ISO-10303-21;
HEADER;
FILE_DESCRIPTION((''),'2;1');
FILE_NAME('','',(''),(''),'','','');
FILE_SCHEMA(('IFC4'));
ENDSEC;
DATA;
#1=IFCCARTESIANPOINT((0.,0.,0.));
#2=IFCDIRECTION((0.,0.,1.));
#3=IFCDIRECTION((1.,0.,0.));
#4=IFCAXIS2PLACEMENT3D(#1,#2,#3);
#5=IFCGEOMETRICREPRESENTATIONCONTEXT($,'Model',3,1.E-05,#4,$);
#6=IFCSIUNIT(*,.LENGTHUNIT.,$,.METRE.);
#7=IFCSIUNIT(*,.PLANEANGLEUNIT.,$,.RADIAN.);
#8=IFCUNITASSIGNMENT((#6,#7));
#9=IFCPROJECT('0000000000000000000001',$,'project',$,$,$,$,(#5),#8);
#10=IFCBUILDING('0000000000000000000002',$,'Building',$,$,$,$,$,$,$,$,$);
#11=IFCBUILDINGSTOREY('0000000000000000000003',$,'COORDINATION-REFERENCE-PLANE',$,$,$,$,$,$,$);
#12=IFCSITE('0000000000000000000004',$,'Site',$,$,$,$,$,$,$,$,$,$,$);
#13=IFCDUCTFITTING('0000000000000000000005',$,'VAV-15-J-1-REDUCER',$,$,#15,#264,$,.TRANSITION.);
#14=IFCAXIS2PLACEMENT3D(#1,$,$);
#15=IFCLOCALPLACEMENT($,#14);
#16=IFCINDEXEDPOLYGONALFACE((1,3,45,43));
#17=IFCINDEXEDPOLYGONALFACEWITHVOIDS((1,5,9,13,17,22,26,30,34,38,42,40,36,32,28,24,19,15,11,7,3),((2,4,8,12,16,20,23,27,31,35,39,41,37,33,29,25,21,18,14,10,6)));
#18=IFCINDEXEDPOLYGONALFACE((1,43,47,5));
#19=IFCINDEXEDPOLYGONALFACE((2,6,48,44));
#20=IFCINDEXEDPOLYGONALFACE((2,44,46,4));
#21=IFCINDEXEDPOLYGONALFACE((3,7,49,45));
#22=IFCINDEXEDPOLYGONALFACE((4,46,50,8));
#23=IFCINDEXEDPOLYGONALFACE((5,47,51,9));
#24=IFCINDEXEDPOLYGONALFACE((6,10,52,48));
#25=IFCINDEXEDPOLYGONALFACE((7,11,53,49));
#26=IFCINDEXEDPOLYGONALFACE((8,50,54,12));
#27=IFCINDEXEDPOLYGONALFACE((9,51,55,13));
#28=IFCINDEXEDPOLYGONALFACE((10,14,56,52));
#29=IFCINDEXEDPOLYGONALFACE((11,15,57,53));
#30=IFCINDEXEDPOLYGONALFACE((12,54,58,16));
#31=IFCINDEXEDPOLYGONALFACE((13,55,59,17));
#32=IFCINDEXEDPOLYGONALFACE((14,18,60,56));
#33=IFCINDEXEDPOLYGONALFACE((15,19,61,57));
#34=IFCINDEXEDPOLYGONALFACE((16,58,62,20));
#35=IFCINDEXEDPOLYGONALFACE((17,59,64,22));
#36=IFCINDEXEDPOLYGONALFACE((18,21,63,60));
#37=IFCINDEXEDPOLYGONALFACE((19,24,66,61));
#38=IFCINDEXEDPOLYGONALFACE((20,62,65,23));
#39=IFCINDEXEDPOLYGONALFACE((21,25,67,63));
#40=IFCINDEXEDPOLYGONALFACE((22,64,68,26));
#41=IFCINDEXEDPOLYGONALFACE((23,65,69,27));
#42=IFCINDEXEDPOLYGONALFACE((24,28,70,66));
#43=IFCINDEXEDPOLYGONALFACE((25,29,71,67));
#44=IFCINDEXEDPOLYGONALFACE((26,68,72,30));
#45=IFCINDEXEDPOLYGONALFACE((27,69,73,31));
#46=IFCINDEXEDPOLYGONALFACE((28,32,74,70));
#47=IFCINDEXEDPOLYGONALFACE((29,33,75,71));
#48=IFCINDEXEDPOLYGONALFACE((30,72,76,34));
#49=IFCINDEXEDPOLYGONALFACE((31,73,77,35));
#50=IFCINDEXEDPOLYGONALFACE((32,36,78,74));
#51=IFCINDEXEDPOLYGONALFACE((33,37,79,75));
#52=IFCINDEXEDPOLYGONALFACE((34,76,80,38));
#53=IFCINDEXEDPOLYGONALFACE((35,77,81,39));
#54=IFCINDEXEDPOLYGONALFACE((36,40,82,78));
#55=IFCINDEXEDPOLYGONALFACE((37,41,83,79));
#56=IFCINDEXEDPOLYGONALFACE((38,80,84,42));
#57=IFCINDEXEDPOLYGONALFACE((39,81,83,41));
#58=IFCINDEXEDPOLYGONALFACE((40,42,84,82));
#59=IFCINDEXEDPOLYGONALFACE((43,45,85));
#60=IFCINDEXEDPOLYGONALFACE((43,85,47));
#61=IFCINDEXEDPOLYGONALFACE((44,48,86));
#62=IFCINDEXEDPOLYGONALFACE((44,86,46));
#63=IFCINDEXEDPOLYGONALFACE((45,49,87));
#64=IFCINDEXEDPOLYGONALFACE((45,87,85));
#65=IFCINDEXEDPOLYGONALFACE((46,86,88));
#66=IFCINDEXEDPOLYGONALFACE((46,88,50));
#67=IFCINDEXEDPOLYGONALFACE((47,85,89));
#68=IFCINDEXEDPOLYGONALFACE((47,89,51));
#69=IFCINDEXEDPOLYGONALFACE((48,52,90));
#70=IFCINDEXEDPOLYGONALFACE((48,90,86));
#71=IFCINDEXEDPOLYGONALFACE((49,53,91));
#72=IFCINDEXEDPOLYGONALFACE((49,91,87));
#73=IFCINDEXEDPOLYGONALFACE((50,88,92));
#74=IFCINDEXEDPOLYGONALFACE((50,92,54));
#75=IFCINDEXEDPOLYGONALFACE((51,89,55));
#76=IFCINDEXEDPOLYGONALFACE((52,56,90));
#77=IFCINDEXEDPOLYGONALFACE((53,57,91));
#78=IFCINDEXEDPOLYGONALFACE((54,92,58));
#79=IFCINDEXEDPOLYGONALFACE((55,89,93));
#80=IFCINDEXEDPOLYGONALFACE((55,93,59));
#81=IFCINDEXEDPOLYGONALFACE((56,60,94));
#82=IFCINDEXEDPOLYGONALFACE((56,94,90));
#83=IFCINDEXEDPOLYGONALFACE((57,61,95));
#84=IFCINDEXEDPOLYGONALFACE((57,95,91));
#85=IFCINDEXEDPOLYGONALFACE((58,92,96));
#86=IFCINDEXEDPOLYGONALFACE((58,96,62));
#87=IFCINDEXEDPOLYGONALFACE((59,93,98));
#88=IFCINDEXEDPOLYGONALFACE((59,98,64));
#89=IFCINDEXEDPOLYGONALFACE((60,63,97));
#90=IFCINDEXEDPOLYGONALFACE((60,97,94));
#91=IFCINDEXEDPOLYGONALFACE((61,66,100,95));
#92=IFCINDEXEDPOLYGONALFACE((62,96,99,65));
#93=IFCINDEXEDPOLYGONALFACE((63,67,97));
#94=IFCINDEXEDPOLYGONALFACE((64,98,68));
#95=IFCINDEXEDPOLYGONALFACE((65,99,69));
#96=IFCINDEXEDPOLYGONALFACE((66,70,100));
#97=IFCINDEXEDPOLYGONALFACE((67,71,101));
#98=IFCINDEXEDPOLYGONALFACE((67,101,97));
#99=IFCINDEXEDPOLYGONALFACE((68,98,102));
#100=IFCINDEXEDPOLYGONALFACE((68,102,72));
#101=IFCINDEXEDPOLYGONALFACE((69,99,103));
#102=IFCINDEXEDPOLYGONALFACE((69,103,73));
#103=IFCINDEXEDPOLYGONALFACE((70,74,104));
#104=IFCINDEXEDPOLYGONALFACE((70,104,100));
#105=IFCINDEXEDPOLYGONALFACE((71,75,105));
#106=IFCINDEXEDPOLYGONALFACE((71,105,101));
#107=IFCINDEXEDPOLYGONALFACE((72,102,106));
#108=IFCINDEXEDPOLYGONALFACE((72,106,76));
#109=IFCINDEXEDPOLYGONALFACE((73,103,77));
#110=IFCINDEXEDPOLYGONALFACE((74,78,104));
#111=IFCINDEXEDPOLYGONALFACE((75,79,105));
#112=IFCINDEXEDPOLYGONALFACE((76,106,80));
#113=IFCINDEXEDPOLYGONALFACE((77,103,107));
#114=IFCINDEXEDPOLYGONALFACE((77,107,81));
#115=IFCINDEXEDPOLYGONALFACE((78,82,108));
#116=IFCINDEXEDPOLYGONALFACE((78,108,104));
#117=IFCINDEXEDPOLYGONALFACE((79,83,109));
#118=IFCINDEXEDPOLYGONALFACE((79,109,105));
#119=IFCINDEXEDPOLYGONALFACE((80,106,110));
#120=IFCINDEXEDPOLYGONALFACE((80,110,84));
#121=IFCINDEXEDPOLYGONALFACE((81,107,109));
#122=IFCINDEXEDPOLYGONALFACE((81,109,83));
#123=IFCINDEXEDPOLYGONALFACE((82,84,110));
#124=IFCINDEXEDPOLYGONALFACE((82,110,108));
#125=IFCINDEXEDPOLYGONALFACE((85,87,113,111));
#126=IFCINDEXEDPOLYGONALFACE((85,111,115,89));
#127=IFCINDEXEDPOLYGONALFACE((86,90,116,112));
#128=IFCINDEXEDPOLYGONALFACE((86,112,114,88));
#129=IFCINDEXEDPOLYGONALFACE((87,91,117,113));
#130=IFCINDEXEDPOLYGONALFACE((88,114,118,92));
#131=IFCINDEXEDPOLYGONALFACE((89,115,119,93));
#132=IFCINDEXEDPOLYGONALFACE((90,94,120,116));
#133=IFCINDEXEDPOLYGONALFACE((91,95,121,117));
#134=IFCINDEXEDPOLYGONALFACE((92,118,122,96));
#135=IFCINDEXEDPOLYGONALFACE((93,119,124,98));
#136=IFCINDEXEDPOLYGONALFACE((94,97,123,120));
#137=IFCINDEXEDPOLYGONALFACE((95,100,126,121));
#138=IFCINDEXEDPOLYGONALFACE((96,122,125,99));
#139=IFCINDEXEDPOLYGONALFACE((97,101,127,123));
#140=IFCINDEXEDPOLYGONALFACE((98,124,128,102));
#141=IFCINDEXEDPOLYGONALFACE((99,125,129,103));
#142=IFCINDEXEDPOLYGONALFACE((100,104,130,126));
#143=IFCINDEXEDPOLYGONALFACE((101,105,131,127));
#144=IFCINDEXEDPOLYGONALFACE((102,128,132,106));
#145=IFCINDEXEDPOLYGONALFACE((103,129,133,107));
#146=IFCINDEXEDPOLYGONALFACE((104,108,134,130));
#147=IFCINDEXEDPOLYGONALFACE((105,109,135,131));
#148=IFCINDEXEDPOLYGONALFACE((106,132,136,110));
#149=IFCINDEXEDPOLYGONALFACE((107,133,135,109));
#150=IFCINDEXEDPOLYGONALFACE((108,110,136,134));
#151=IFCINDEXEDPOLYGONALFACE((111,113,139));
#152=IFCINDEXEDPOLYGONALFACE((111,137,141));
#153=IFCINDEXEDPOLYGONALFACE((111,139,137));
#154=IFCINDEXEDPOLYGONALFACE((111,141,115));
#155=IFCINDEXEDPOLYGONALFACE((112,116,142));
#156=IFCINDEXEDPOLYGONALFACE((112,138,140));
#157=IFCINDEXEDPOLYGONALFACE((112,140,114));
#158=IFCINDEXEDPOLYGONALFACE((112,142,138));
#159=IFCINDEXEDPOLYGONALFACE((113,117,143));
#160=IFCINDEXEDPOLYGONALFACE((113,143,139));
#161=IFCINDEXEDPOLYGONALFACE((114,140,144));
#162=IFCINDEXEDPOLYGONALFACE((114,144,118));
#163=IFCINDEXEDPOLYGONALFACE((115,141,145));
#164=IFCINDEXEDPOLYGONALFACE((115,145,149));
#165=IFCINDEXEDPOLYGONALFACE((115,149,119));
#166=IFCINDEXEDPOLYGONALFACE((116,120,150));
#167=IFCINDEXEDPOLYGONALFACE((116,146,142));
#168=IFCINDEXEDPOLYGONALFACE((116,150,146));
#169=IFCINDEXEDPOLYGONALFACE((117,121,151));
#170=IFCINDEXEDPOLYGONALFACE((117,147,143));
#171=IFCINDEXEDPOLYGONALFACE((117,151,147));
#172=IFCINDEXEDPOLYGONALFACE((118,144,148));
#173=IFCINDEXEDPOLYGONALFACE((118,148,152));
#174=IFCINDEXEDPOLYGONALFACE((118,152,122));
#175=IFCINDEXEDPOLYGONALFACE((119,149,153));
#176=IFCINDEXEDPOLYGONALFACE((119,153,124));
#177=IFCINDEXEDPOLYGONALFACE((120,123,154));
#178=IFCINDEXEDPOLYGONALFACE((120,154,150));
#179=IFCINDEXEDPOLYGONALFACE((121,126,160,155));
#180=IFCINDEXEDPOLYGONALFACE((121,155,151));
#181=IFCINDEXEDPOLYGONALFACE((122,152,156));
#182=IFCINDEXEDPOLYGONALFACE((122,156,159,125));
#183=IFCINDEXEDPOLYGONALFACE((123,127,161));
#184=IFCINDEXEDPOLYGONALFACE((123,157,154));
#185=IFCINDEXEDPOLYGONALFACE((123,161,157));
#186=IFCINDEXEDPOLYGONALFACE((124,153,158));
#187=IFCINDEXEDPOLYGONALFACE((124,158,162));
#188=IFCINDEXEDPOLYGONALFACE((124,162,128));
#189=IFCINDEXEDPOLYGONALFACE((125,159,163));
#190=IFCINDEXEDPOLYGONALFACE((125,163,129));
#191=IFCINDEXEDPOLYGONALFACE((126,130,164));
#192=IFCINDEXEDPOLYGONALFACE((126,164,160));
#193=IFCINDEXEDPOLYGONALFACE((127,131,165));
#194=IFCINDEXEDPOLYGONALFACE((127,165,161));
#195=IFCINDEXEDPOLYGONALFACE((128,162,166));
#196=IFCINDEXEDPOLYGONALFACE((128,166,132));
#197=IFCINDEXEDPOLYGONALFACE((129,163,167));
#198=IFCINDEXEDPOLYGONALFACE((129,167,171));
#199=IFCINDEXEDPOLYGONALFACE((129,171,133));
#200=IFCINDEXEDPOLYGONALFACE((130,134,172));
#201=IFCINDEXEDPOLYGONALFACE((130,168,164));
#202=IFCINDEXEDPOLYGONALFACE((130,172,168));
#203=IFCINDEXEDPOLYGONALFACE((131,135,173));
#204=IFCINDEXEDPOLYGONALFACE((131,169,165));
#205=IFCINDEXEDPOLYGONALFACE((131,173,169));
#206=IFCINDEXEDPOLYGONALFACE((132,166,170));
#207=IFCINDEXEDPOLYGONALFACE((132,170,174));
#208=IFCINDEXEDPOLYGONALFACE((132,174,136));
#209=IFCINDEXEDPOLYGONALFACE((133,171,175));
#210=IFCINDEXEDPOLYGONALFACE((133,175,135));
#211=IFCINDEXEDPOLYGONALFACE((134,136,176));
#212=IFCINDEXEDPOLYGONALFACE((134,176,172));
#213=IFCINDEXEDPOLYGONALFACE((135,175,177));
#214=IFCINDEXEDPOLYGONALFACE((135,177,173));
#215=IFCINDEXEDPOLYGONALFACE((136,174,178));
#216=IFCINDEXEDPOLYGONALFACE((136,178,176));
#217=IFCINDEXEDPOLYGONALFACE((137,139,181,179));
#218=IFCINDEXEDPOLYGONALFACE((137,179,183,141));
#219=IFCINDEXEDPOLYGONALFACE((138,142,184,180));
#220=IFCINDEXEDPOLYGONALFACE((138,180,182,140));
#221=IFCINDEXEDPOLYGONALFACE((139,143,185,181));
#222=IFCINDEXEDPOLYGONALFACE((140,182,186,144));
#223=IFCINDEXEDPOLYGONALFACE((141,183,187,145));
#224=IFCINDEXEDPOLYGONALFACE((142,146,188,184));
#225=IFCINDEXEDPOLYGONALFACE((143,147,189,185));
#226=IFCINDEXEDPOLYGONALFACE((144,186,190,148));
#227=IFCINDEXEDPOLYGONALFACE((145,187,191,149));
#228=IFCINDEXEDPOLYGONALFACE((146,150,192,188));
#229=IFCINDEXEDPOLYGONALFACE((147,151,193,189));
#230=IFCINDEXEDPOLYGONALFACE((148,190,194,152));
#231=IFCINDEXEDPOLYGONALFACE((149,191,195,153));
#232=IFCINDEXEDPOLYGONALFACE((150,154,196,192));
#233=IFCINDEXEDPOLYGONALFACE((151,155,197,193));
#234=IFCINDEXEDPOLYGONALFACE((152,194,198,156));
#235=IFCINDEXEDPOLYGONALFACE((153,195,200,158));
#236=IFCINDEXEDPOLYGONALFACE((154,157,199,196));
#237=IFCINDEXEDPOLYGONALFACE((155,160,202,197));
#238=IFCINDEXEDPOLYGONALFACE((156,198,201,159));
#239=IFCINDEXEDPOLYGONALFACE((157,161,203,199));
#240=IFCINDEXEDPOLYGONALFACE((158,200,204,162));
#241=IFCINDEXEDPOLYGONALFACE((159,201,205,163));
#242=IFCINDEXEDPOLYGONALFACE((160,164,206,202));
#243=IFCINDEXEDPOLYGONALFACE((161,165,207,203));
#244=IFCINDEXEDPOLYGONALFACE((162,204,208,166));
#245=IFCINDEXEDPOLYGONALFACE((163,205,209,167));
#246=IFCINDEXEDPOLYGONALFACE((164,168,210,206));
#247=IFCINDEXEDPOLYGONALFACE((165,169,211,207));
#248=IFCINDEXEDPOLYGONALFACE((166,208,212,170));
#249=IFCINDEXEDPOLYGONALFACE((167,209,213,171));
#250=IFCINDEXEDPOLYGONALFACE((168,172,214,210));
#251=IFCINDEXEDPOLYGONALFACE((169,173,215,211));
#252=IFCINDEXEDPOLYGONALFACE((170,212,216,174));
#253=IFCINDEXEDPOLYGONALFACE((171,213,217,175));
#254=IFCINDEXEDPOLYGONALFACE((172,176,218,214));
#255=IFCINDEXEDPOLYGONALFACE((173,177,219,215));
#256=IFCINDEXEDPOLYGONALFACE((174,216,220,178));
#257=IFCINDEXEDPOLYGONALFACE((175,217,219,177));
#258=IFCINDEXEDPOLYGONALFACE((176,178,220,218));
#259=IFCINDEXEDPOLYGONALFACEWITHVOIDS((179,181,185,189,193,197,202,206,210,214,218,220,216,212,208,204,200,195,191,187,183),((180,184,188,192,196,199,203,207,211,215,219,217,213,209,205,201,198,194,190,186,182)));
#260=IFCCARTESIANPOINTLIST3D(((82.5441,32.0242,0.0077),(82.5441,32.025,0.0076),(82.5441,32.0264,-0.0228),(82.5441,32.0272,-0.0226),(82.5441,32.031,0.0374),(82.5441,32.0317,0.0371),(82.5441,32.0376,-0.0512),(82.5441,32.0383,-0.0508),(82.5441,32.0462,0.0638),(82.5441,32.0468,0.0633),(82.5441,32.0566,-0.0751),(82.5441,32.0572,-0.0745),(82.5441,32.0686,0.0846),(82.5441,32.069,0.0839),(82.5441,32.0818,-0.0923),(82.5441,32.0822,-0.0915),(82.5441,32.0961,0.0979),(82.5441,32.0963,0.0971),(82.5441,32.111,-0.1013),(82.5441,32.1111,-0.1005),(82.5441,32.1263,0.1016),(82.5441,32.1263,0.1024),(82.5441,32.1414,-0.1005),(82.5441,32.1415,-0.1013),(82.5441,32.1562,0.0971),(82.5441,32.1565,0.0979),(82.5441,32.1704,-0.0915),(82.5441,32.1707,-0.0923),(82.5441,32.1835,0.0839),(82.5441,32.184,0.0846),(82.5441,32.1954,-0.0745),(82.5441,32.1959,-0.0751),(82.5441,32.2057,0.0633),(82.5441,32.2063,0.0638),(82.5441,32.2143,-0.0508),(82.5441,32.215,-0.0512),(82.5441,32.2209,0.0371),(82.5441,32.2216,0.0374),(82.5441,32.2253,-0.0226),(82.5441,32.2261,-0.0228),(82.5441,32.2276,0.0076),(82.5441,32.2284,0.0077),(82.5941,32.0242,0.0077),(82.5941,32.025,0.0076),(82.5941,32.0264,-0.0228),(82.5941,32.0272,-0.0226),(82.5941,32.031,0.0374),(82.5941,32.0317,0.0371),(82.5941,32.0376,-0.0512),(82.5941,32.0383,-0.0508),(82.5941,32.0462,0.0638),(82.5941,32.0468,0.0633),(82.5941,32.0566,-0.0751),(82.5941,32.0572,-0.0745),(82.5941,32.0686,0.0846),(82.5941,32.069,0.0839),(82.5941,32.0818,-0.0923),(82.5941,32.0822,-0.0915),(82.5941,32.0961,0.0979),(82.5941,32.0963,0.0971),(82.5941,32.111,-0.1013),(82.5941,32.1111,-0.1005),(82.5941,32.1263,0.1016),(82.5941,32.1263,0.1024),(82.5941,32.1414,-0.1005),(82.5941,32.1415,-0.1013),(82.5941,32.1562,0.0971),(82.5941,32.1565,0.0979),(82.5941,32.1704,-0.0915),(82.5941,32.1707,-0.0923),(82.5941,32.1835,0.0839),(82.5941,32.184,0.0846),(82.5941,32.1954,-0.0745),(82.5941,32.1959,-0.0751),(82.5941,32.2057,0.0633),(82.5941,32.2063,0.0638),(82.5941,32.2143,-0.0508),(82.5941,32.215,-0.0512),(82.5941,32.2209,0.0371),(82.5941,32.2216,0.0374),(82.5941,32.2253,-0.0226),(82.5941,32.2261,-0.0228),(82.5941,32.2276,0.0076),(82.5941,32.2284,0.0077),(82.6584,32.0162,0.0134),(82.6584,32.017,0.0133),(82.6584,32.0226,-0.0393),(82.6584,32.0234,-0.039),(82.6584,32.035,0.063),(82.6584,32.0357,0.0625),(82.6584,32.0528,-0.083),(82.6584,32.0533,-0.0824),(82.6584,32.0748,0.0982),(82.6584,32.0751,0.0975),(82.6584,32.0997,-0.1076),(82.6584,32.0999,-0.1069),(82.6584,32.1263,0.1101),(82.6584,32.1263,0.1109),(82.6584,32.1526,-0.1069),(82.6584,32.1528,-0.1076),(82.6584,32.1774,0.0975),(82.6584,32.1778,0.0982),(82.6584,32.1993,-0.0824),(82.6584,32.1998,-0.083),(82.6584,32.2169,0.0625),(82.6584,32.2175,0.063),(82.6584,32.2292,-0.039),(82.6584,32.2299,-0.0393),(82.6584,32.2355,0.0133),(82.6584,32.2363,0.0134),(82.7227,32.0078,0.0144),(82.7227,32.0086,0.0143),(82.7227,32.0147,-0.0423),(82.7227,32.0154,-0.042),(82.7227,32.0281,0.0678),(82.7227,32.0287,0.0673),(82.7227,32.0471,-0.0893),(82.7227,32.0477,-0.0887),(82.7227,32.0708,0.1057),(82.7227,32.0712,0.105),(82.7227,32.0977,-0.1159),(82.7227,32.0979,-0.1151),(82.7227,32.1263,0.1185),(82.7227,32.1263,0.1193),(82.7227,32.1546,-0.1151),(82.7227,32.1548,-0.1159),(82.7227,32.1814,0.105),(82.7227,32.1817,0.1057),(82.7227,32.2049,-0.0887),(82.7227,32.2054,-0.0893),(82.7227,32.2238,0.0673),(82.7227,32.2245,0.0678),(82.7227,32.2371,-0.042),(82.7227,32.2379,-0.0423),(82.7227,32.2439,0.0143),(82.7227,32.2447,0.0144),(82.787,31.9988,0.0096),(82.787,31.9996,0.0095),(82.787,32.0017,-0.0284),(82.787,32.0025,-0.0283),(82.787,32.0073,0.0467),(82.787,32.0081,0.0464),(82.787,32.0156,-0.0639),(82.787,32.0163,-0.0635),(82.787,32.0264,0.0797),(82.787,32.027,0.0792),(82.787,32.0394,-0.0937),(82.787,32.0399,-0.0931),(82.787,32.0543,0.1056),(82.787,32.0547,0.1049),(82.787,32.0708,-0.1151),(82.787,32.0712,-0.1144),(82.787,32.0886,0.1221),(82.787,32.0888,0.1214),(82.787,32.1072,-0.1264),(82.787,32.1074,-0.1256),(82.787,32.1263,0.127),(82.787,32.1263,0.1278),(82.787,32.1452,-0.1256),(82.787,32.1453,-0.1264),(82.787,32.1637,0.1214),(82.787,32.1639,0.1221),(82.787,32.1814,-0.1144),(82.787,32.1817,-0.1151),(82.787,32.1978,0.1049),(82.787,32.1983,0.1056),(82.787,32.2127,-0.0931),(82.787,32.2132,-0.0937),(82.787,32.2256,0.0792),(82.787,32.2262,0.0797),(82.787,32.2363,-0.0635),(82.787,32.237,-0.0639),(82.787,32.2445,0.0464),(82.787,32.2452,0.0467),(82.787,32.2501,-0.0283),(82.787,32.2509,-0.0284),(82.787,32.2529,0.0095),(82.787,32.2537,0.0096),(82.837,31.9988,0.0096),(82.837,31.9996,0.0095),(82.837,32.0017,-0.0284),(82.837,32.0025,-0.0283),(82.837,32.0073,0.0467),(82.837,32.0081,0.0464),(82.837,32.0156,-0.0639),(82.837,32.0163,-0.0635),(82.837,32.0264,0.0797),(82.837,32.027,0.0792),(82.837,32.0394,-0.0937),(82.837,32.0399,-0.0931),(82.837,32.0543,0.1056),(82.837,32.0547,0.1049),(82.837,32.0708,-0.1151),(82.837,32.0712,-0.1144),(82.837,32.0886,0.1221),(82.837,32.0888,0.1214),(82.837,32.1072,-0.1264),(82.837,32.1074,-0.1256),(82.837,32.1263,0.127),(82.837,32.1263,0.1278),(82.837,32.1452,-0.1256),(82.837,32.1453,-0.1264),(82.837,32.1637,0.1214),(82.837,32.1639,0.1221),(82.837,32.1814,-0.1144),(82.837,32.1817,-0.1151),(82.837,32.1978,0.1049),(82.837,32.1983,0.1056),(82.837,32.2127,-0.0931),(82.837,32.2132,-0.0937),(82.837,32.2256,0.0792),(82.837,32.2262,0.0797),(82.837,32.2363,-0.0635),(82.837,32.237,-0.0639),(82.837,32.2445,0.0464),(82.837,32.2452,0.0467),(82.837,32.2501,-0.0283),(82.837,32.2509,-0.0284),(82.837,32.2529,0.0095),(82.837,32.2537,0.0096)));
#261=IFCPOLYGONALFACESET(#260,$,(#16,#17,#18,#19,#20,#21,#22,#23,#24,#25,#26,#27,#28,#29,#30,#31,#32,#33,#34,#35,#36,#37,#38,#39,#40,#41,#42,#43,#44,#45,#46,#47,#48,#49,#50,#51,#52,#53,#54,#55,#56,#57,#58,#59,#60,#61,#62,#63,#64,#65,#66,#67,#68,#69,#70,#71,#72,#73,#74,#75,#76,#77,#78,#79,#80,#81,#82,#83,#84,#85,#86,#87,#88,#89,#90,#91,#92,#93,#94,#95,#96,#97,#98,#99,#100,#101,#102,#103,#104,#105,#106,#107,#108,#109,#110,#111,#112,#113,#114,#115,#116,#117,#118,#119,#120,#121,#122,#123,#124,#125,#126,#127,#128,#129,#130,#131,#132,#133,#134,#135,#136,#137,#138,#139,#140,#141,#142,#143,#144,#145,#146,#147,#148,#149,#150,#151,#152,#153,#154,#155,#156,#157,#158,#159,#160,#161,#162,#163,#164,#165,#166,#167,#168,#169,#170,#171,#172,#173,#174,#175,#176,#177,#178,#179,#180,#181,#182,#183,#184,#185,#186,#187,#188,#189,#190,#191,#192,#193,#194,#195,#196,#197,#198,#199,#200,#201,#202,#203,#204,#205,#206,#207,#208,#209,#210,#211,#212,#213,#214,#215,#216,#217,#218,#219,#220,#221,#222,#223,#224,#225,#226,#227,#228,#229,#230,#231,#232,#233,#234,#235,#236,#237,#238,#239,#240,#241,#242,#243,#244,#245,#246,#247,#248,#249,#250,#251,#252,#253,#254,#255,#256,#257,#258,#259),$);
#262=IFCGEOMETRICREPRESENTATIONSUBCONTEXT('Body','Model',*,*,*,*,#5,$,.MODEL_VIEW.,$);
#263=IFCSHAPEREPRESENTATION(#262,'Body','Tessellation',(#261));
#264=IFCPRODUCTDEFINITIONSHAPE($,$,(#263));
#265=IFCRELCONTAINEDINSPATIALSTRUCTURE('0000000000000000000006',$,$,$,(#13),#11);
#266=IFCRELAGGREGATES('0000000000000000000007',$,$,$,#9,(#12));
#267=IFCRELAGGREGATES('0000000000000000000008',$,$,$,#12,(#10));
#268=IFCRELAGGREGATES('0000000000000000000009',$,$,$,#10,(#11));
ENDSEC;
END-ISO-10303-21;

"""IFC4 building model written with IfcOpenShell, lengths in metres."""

from ifc_helpers import new_model, entity, si_unit, frame, origin_with_axes, place, context, subcontext, project, spatial, element, save


model = new_model("IFC4")

# Units and contexts
model_context_1 = context("Model", 3, precision=1e-05, world=origin_with_axes())
body_context_1 = subcontext(model_context_1, "Body", "Model", "MODEL_VIEW")
ifc_project = project(units=[si_unit("LENGTHUNIT", "METRE"), si_unit("PLANEANGLEUNIT", "RADIAN")], contexts=[model_context_1])

# Site, building, storey
site = spatial("IfcSite", under=ifc_project, Name="Site")
building = spatial("IfcBuilding", under=site, Name="Building")
storey = spatial("IfcBuildingStorey", under=building, Name="COORDINATION-REFERENCE-PLANE")

# Duct fitting
for number, where, z_axis, x_axis, name in (
    (1, (82.837, 32.1263, 0.0), (0.0, -1.0, 0.0), (0.0, 0.0, 1.0), "VAV-15-J-1-REDUCER"),
):
    element("IfcDuctFitting", number, at=place(None, frame(where, z_axis=z_axis, x_axis=x_axis)), inside=storey, Name=name, PredefinedType="TRANSITION", context=body_context_1, shape_type="SweptSolid", body=[
        entity("IfcRevolvedAreaSolid", entity("IfcArbitraryClosedProfileDef", "AREA", None, entity("IfcPolyline", [entity("IfcCartesianPoint", [0.1278, 0.0]), entity("IfcCartesianPoint", [0.1278, 0.05]), entity("IfcCartesianPoint", [0.1024, 0.2429]), entity("IfcCartesianPoint", [0.1024, 0.2929]), entity("IfcCartesianPoint", [0.1016, 0.2929]), entity("IfcCartesianPoint", [0.1016, 0.2429]), entity("IfcCartesianPoint", [0.127, 0.05]), entity("IfcCartesianPoint", [0.127, 0.0]), entity("IfcCartesianPoint", [0.1278, 0.0])])), entity("IfcAxis2Placement3D", entity("IfcCartesianPoint", [0.0, 0.0, 0.0])), entity("IfcAxis1Placement", entity("IfcCartesianPoint", [0.0, 0.0, 0.0]), entity("IfcDirection", [0.0, 1.0, 0.0])), 6.283185),
    ])

save(model, "model.ifc")
